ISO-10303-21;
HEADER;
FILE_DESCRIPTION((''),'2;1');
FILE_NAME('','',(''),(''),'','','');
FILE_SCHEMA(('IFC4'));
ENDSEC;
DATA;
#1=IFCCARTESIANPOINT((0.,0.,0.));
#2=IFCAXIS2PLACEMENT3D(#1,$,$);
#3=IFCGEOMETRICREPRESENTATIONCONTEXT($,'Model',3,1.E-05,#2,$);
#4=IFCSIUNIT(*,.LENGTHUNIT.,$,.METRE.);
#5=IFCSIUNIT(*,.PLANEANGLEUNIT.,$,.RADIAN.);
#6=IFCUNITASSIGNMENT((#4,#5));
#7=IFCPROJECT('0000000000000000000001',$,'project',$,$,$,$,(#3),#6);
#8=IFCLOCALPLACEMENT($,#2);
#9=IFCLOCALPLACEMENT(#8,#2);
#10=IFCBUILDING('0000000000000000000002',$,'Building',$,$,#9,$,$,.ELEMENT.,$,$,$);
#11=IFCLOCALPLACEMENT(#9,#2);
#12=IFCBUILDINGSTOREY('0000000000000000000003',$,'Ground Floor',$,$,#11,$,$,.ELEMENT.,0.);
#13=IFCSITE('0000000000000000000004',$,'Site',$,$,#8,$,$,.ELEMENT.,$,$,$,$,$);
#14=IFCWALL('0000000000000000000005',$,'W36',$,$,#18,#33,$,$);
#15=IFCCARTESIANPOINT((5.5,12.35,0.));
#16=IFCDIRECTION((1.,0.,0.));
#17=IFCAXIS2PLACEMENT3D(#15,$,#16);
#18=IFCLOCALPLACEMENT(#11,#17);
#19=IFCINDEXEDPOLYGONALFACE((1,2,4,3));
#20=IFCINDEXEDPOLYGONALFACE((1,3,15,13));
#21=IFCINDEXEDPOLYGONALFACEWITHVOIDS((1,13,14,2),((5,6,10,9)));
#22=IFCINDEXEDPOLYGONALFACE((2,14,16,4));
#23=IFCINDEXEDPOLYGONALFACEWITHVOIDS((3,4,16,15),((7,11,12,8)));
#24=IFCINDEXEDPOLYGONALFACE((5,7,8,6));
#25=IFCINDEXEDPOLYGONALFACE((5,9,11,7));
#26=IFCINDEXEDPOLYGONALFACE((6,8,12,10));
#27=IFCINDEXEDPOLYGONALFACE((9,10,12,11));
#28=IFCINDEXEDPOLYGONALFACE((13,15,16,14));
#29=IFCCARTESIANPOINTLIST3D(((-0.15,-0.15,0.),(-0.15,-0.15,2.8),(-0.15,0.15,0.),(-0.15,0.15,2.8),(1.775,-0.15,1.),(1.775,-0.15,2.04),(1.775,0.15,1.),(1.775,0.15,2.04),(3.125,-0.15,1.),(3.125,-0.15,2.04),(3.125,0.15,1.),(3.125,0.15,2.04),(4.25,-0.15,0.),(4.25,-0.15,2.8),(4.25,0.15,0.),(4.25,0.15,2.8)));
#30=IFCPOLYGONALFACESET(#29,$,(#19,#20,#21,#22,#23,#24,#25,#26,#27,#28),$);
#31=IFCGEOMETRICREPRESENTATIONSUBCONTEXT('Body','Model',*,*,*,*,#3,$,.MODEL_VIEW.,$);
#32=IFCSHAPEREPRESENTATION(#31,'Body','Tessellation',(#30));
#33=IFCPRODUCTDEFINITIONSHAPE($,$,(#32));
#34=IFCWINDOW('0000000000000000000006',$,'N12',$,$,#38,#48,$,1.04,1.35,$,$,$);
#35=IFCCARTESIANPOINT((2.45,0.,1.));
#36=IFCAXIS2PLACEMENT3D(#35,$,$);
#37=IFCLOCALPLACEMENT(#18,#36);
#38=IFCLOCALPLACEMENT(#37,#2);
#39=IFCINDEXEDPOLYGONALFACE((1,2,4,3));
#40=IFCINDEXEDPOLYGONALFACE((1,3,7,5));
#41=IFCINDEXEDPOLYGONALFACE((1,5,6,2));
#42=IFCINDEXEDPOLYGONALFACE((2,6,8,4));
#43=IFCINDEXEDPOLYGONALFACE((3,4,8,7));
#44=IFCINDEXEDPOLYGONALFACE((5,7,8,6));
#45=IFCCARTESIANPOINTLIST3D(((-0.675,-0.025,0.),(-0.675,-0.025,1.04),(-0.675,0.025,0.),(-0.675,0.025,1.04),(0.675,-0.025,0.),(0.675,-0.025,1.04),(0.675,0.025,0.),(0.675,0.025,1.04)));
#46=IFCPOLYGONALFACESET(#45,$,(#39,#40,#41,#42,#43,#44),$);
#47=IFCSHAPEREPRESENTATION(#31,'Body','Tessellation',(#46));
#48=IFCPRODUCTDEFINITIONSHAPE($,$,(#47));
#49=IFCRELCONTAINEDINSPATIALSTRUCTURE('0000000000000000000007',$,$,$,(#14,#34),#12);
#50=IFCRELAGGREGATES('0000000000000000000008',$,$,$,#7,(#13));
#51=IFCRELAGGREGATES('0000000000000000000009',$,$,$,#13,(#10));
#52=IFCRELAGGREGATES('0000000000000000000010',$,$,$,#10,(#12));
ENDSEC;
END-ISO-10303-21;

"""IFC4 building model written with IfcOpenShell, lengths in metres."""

from ifc_helpers import new_model, si_unit, frame, frame_2d, origin, origin_2d, place, context, subcontext, project, spatial, rectangle, extrude, element, fill, save


model = new_model("IFC4")

# Units and contexts
model_context = context("Model", 3, precision=1e-05, world=origin())
body_context = subcontext(model_context, "Body", "Model", "MODEL_VIEW")
ifc_project = project(units=[si_unit("LENGTHUNIT", "METRE"), si_unit("PLANEANGLEUNIT", "RADIAN")], contexts=[model_context])

# Site, building, storey
site_placement = place(None, origin())
site = spatial("IfcSite", under=ifc_project, at=site_placement, Name="Site", CompositionType="ELEMENT")
building_placement = place(site_placement, origin())
building = spatial("IfcBuilding", under=site, at=building_placement, Name="Building", CompositionType="ELEMENT")
storey_placement = place(building_placement, origin())
storey = spatial("IfcBuildingStorey", under=building, at=storey_placement, Name="Ground Floor", CompositionType="ELEMENT", Elevation=0.0)

# Wall, opening, window
wall_1_placement = place(storey_placement, frame((5.5, 12.35, 0.0), x_axis=(1.0, 0.0, 0.0)))
wall_1 = element("IfcWall", 1, at=wall_1_placement, inside=storey, Name="W36", context=body_context, shape_type="SweptSolid", body=[
    extrude(rectangle(XDim=4.4, YDim=0.3, at=frame_2d((2.05, 0.0))), origin(), (0.0, 0.0, 1.0), 2.8),
])
opening_1_placement = place(wall_1_placement, frame((2.45, 0.0, 1.0)))
opening_1 = element("IfcOpeningElement", 2, at=opening_1_placement, cuts=wall_1, context=body_context, shape_type="SweptSolid", body=[
    extrude(rectangle(XDim=1.35, YDim=0.4, at=origin_2d()), origin(), (0.0, 0.0, 1.0), 1.04),
])
window_1_placement = place(opening_1_placement, origin())
window_1 = element("IfcWindow", 3, at=window_1_placement, inside=storey, Name="N12", OverallHeight=1.04, OverallWidth=1.35, context=body_context, shape_type="SweptSolid", body=[
    extrude(rectangle(XDim=1.35, YDim=0.05, at=origin_2d()), origin(), (0.0, 0.0, 1.0), 1.04),
])
fill(opening_1, window_1)

save(model, "model.ifc")
